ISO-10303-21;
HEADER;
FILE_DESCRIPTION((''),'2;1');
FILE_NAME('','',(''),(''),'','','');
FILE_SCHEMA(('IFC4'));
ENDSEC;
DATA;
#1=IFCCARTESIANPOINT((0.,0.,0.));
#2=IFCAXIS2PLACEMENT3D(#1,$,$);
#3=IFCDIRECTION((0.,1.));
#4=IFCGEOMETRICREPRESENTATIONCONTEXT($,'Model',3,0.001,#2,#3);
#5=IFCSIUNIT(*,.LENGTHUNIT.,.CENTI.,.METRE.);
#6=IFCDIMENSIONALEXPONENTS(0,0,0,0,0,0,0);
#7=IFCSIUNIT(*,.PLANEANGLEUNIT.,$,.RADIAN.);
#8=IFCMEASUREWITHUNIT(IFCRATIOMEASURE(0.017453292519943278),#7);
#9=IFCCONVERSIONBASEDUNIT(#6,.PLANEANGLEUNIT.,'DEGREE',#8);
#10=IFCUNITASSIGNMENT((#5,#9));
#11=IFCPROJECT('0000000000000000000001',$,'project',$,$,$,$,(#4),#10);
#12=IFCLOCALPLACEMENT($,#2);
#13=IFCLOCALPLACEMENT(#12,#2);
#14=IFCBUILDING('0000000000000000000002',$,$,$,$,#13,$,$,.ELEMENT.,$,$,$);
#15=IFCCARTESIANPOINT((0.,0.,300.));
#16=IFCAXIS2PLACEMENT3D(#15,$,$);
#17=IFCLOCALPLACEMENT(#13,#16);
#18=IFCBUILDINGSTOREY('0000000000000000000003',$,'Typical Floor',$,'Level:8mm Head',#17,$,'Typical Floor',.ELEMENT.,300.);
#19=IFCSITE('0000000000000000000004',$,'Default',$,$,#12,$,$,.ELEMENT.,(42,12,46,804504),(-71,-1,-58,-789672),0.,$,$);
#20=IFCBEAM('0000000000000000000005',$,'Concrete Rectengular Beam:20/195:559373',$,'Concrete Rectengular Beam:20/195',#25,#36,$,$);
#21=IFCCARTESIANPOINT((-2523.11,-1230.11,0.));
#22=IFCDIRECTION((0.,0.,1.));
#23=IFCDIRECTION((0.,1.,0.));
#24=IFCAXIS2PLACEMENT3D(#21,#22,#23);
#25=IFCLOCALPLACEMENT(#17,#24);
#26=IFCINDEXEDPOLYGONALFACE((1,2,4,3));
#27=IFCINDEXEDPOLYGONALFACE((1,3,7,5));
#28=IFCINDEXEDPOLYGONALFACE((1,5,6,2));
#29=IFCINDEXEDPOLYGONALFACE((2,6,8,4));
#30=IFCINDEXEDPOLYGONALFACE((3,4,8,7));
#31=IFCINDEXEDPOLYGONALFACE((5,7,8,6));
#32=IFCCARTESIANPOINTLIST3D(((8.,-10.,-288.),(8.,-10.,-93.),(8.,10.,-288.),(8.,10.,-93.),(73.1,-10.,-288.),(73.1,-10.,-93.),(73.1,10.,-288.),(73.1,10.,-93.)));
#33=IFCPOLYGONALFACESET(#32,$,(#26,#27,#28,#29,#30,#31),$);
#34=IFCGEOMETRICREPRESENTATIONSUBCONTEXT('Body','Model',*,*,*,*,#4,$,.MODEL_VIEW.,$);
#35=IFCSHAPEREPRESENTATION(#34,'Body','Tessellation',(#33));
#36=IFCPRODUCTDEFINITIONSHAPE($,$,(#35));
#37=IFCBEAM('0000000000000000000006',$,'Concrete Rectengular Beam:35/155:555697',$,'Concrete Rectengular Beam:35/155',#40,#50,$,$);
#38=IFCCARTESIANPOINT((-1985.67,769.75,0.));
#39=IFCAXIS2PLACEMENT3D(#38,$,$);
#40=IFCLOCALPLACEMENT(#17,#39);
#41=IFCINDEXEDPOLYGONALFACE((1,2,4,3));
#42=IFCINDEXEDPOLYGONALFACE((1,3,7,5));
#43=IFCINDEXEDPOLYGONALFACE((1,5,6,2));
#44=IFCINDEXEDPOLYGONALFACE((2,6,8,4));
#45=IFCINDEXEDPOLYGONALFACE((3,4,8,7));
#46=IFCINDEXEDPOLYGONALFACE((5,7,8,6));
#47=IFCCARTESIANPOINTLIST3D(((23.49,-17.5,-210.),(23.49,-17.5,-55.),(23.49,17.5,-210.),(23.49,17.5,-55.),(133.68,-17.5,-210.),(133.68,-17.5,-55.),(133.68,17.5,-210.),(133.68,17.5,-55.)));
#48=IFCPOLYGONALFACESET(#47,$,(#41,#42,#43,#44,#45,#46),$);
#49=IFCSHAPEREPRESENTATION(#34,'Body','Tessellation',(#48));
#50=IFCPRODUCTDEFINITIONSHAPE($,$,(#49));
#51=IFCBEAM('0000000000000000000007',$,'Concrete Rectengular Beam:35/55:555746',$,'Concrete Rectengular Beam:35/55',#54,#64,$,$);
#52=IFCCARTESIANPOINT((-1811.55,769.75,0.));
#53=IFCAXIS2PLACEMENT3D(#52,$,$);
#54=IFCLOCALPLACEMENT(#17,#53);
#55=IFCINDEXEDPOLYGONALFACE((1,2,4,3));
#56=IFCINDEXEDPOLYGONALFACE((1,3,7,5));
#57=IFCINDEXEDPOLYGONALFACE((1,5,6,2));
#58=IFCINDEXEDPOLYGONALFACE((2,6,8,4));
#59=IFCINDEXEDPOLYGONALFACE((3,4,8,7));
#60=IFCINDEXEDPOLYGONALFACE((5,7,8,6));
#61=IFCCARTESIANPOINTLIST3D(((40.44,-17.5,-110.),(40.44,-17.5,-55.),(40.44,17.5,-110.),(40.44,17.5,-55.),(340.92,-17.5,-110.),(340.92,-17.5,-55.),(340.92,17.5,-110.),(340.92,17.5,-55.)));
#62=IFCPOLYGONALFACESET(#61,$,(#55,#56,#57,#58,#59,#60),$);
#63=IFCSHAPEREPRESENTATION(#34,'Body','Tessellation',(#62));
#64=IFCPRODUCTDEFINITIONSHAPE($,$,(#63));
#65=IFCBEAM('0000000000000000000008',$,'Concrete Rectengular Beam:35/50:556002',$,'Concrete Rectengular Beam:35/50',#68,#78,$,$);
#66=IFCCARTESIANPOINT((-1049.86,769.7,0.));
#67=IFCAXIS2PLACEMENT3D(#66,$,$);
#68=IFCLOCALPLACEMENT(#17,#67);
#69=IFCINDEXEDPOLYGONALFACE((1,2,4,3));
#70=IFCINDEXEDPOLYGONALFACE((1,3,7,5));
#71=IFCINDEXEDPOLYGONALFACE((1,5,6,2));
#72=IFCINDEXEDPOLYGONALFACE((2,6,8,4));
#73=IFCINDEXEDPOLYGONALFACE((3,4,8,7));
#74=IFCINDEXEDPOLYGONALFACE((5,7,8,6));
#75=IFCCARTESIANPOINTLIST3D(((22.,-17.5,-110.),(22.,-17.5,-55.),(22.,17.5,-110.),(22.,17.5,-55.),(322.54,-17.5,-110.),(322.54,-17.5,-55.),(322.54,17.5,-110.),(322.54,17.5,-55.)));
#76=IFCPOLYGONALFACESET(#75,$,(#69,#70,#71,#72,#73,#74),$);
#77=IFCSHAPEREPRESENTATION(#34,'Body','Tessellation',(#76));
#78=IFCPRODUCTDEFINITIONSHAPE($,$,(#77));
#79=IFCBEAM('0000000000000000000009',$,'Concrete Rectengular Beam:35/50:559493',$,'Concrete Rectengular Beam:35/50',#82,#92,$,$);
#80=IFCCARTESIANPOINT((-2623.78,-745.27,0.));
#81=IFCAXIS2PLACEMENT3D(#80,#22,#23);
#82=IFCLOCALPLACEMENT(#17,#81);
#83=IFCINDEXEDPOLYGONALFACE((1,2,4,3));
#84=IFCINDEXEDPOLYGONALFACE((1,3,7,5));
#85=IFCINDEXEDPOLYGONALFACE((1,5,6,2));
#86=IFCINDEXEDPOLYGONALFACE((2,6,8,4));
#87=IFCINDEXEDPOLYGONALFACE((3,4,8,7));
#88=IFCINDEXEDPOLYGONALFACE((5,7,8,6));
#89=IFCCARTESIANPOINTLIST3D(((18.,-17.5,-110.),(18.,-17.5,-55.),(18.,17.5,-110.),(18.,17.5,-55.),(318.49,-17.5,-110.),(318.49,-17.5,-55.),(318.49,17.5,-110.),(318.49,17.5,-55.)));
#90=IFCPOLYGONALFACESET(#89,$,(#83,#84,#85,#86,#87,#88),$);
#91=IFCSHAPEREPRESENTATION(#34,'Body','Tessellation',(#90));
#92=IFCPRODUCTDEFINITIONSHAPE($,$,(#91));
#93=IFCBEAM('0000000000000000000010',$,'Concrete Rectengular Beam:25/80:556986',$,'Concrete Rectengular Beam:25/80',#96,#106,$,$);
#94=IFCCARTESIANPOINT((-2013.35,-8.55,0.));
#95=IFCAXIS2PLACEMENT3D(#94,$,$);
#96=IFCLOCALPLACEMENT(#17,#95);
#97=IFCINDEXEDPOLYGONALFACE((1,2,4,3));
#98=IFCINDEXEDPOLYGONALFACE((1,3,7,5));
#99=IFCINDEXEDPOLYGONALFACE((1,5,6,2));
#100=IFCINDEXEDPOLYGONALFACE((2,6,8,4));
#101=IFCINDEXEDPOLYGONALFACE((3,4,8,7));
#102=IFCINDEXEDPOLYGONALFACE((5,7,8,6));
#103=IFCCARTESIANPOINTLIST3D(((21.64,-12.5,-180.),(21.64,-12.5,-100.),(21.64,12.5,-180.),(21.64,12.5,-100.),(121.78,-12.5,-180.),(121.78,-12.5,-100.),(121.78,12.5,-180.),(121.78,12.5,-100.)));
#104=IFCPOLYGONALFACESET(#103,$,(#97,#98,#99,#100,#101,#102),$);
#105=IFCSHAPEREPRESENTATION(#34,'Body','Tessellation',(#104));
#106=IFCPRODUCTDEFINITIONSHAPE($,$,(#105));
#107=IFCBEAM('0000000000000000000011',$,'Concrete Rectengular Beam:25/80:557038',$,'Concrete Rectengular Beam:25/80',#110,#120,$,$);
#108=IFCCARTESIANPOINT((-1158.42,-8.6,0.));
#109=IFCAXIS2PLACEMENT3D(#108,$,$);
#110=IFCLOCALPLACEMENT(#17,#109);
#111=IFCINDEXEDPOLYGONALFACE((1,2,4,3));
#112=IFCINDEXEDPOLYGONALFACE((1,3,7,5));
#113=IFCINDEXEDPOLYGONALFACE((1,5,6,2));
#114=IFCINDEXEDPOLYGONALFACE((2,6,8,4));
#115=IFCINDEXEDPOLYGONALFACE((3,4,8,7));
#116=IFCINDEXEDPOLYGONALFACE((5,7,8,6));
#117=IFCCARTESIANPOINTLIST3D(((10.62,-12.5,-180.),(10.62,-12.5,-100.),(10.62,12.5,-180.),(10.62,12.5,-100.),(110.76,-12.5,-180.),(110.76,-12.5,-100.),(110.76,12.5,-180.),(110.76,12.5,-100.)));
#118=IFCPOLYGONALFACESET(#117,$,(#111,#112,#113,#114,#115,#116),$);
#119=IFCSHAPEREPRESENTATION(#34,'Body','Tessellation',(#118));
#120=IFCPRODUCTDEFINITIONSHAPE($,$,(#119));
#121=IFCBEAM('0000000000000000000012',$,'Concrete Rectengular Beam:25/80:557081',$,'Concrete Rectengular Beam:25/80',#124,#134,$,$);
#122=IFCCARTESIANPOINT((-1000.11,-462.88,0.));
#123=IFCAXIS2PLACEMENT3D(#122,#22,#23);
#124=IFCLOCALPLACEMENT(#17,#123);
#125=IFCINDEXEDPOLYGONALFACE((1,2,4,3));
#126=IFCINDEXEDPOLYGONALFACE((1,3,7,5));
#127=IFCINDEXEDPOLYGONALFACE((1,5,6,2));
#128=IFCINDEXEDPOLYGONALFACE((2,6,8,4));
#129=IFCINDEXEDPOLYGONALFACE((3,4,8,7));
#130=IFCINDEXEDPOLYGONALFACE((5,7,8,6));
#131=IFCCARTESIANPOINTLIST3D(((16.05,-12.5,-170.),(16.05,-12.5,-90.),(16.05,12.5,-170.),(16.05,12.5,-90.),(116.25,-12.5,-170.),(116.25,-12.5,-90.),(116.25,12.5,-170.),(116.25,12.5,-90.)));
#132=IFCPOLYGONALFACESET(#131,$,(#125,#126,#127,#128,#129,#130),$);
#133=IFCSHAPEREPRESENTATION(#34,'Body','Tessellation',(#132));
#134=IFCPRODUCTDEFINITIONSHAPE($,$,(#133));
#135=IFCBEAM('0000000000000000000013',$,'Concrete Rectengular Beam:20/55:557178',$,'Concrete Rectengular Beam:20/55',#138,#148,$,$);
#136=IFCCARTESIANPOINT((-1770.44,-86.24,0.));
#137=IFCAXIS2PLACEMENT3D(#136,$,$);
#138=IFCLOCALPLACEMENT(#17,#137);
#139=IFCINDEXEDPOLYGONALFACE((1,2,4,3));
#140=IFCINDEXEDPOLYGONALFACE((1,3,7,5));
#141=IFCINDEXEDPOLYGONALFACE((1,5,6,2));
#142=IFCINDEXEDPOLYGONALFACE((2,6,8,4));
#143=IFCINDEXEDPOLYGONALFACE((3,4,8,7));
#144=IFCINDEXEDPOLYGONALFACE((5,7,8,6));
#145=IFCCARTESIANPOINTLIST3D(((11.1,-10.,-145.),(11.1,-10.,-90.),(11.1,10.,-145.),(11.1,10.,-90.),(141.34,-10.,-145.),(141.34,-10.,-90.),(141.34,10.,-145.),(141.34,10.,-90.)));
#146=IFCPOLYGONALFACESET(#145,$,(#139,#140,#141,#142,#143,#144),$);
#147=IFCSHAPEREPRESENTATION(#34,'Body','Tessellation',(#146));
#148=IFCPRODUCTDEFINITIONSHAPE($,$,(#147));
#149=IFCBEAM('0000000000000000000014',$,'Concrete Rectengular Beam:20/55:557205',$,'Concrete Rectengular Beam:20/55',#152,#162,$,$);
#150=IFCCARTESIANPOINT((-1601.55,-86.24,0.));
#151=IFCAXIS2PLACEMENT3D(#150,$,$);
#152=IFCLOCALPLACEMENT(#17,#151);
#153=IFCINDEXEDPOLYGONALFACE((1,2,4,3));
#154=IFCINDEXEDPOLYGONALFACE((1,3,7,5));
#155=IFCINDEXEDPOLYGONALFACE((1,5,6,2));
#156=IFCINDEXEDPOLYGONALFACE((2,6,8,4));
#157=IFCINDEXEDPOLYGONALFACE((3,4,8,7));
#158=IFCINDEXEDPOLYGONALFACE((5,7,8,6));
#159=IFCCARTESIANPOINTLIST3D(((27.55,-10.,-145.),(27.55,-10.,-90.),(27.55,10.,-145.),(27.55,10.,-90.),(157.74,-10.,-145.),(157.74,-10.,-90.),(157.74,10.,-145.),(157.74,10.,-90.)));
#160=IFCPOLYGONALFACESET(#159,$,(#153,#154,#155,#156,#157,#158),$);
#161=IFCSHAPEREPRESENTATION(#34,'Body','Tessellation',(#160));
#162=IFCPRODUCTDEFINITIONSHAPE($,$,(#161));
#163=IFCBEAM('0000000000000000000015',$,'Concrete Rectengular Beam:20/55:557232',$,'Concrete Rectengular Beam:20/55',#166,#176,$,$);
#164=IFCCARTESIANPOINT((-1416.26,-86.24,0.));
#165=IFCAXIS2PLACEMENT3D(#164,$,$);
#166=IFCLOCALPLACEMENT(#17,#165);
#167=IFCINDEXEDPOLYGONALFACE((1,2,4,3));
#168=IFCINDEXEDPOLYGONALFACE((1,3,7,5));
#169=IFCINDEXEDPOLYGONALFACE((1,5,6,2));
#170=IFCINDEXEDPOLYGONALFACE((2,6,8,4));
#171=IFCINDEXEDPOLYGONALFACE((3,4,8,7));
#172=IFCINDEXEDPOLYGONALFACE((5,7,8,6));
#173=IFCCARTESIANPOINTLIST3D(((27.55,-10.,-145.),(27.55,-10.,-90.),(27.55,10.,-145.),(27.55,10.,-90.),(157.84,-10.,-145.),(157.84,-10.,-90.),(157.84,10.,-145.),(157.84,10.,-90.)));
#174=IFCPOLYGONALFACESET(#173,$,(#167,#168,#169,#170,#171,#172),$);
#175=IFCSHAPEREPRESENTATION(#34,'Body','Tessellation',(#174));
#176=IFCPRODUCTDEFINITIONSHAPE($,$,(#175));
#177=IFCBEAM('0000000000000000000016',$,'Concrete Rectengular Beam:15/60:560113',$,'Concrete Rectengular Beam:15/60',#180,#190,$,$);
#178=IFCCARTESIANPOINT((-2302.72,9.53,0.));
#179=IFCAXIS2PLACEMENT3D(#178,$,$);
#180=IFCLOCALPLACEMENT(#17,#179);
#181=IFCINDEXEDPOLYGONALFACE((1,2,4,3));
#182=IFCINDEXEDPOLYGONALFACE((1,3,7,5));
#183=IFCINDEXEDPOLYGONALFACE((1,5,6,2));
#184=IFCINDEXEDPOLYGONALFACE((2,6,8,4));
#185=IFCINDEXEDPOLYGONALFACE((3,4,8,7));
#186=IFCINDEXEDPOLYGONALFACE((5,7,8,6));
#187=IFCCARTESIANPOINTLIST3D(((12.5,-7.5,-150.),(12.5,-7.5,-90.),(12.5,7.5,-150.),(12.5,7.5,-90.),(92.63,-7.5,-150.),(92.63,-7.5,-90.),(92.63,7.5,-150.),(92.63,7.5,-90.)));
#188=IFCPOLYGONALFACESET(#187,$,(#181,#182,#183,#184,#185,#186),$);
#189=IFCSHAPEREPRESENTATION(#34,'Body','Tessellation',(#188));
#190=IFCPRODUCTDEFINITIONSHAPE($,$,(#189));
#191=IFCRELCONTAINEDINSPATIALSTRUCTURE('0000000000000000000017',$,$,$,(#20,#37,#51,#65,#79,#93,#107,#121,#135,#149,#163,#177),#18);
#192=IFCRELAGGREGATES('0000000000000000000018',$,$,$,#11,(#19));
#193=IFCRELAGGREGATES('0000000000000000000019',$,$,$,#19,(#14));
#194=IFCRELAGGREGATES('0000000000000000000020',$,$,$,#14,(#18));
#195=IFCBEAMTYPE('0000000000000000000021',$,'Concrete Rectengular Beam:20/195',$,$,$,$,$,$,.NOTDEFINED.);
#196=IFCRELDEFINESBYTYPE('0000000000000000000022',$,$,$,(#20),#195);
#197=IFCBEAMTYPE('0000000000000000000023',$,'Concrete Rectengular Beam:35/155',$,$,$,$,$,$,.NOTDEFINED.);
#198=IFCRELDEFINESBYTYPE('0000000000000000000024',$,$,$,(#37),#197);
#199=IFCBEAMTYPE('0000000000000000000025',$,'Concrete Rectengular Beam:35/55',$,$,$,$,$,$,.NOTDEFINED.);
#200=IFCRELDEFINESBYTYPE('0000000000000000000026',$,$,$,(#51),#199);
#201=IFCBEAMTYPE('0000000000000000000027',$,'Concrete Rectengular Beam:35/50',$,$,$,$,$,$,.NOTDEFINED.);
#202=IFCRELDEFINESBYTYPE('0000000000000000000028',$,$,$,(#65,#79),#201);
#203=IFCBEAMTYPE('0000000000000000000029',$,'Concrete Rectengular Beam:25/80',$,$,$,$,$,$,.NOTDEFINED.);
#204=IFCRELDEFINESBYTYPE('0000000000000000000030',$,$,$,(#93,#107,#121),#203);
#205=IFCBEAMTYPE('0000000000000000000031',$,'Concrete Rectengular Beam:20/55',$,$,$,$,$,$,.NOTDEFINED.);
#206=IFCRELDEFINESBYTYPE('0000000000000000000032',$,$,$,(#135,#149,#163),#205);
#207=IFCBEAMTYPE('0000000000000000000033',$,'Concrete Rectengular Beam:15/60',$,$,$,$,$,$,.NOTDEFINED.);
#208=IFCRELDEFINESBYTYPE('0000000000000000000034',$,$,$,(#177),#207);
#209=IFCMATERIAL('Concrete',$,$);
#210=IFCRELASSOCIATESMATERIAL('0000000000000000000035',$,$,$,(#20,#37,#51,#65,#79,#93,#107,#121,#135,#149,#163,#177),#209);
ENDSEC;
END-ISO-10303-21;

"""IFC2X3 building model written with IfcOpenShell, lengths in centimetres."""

from ifc_helpers import new_model, entity, si_unit, converted_unit, direction, frame, frame_2d, origin, origin_2d_with_axis, place, context, subcontext, project, spatial, rectangle, extrude, material, type_object, element, save


model = new_model("IFC2X3")

# Units and contexts
model_context = context("Model", 3, precision=0.001, world=origin(), true_north=direction((0.0, 1.0)))
body_context = subcontext(model_context, "Body", "Model", "MODEL_VIEW")
ifc_project = project(units=[si_unit("LENGTHUNIT", "METRE", prefix="CENTI"), converted_unit("PLANEANGLEUNIT", "DEGREE", entity("IfcRatioMeasure", 0.017453292519943278), si_unit("PLANEANGLEUNIT", "RADIAN"), dimensions=[0, 0, 0, 0, 0, 0, 0])], contexts=[model_context])

# Site, building, storey
site_placement = place(None, origin())
site = spatial("IfcSite", under=ifc_project, at=site_placement, Name="Default", CompositionType="ELEMENT", RefLatitude=(42, 12, 46, 804504), RefLongitude=(-71, -1, -58, -789672), RefElevation=0.0)
building_placement = place(site_placement, origin())
building = spatial("IfcBuilding", under=site, at=building_placement, CompositionType="ELEMENT")
storey_placement = place(building_placement, frame((0.0, 0.0, 300.0)))
storey = spatial("IfcBuildingStorey", under=building, at=storey_placement, Name="Typical Floor", ObjectType="Level:8mm Head", LongName="Typical Floor", CompositionType="ELEMENT", Elevation=300.0)

# Beams
ifc_material = material(Name="Concrete")
beam_type_1 = type_object("IfcBeamType", Name="Concrete Rectengular Beam:20/195", PredefinedType="NOTDEFINED")
beam_1_placement = place(storey_placement, frame((-2523.11, -1230.11, 0.0), z_axis=(0.0, 0.0, 1.0), x_axis=(0.0, 1.0, 0.0)))
element("IfcBeam", 1, at=beam_1_placement, inside=storey, type_object=beam_type_1, material=ifc_material, Name="Concrete Rectengular Beam:20/195:559373", ObjectType="Concrete Rectengular Beam:20/195", context=body_context, shape_type="SweptSolid", body=[
    extrude(rectangle(XDim=195.0, YDim=20.0, at=frame_2d((0.0, 0.0), x_axis=(1.0, 0.0))), frame((8.0, 0.0, -190.5), z_axis=(1.0, 0.0, 0.0), x_axis=(0.0, 0.0, -1.0)), (0.0, 0.0, 1.0), 65.1),
])
beam_type_2 = type_object("IfcBeamType", Name="Concrete Rectengular Beam:35/155", PredefinedType="NOTDEFINED")
beam_2_placement = place(storey_placement, frame((-1985.67, 769.75, 0.0)))
element("IfcBeam", 2, at=beam_2_placement, inside=storey, type_object=beam_type_2, material=ifc_material, Name="Concrete Rectengular Beam:35/155:555697", ObjectType="Concrete Rectengular Beam:35/155", context=body_context, shape_type="SweptSolid", body=[
    extrude(rectangle(XDim=155.0, YDim=35.0, at=frame_2d((0.0, 0.0), x_axis=(1.0, 0.0))), frame((23.49, 0.0, -132.5), z_axis=(1.0, 0.0, 0.0), x_axis=(0.0, 0.0, -1.0)), (0.0, 0.0, 1.0), 110.2),
])
beam_type_3 = type_object("IfcBeamType", Name="Concrete Rectengular Beam:35/55", PredefinedType="NOTDEFINED")
beam_3_placement = place(storey_placement, frame((-1811.55, 769.75, 0.0)))
element("IfcBeam", 3, at=beam_3_placement, inside=storey, type_object=beam_type_3, material=ifc_material, Name="Concrete Rectengular Beam:35/55:555746", ObjectType="Concrete Rectengular Beam:35/55", context=body_context, shape_type="SweptSolid", body=[
    extrude(rectangle(XDim=55.0, YDim=35.0, at=frame_2d((0.0, 0.0), x_axis=(1.0, 0.0))), frame((40.44, 0.0, -82.5), z_axis=(1.0, 0.0, 0.0), x_axis=(0.0, 0.0, -1.0)), (0.0, 0.0, 1.0), 300.49),
])
beam_type_4 = type_object("IfcBeamType", Name="Concrete Rectengular Beam:35/50", PredefinedType="NOTDEFINED")
beam_4_placement = place(storey_placement, frame((-1049.86, 769.7, 0.0)))
element("IfcBeam", 4, at=beam_4_placement, inside=storey, type_object=beam_type_4, material=ifc_material, Name="Concrete Rectengular Beam:35/50:556002", ObjectType="Concrete Rectengular Beam:35/50", context=body_context, shape_type="SweptSolid", body=[
    extrude(rectangle(XDim=55.0, YDim=35.0, at=frame_2d((0.0, 0.0), x_axis=(1.0, 0.0))), frame((22.0, 0.0, -82.5), z_axis=(1.0, 0.0, 0.0), x_axis=(0.0, 0.0, -1.0)), (0.0, 0.0, 1.0), 300.54),
])
beam_5_placement = place(storey_placement, frame((-2623.78, -745.27, 0.0), z_axis=(0.0, 0.0, 1.0), x_axis=(0.0, 1.0, 0.0)))
element("IfcBeam", 5, at=beam_5_placement, inside=storey, type_object=beam_type_4, material=ifc_material, Name="Concrete Rectengular Beam:35/50:559493", ObjectType="Concrete Rectengular Beam:35/50", context=body_context, shape_type="SweptSolid", body=[
    extrude(rectangle(XDim=55.0, YDim=35.0, at=origin_2d_with_axis()), frame((18.0, 0.0, -82.5), z_axis=(1.0, 0.0, 0.0), x_axis=(0.0, 0.0, -1.0)), (0.0, 0.0, 1.0), 300.49),
])
beam_type_5 = type_object("IfcBeamType", Name="Concrete Rectengular Beam:25/80", PredefinedType="NOTDEFINED")
beam_6_placement = place(storey_placement, frame((-2013.35, -8.55, 0.0)))
element("IfcBeam", 6, at=beam_6_placement, inside=storey, type_object=beam_type_5, material=ifc_material, Name="Concrete Rectengular Beam:25/80:556986", ObjectType="Concrete Rectengular Beam:25/80", context=body_context, shape_type="SweptSolid", body=[
    extrude(rectangle(XDim=80.0, YDim=25.0, at=frame_2d((0.0, 0.0), x_axis=(1.0, 0.0))), frame((21.64, 0.0, -140.0), z_axis=(1.0, 0.0, 0.0), x_axis=(0.0, 0.0, -1.0)), (0.0, 0.0, 1.0), 100.14),
])
beam_7_placement = place(storey_placement, frame((-1158.42, -8.6, 0.0)))
element("IfcBeam", 7, at=beam_7_placement, inside=storey, type_object=beam_type_5, material=ifc_material, Name="Concrete Rectengular Beam:25/80:557038", ObjectType="Concrete Rectengular Beam:25/80", context=body_context, shape_type="SweptSolid", body=[
    extrude(rectangle(XDim=80.0, YDim=25.0, at=frame_2d((0.0, 0.0), x_axis=(1.0, 0.0))), frame((10.62, 0.0, -140.0), z_axis=(1.0, 0.0, 0.0), x_axis=(0.0, 0.0, -1.0)), (0.0, 0.0, 1.0), 100.14),
])
beam_8_placement = place(storey_placement, frame((-1000.11, -462.88, 0.0), z_axis=(0.0, 0.0, 1.0), x_axis=(0.0, 1.0, 0.0)))
element("IfcBeam", 8, at=beam_8_placement, inside=storey, type_object=beam_type_5, material=ifc_material, Name="Concrete Rectengular Beam:25/80:557081", ObjectType="Concrete Rectengular Beam:25/80", context=body_context, shape_type="SweptSolid", body=[
    extrude(rectangle(XDim=80.0, YDim=25.0, at=origin_2d_with_axis()), frame((16.05, 0.0, -130.0), z_axis=(1.0, 0.0, 0.0), x_axis=(0.0, 0.0, -1.0)), (0.0, 0.0, 1.0), 100.2),
])
beam_type_6 = type_object("IfcBeamType", Name="Concrete Rectengular Beam:20/55", PredefinedType="NOTDEFINED")
beam_9_placement = place(storey_placement, frame((-1770.44, -86.24, 0.0)))
element("IfcBeam", 9, at=beam_9_placement, inside=storey, type_object=beam_type_6, material=ifc_material, Name="Concrete Rectengular Beam:20/55:557178", ObjectType="Concrete Rectengular Beam:20/55", context=body_context, shape_type="SweptSolid", body=[
    extrude(rectangle(XDim=55.0, YDim=20.0, at=frame_2d((0.0, 0.0), x_axis=(1.0, 0.0))), frame((11.1, 0.0, -117.5), z_axis=(1.0, 0.0, 0.0), x_axis=(0.0, 0.0, -1.0)), (0.0, 0.0, 1.0), 130.25),
])
beam_10_placement = place(storey_placement, frame((-1601.55, -86.24, 0.0)))
element("IfcBeam", 10, at=beam_10_placement, inside=storey, type_object=beam_type_6, material=ifc_material, Name="Concrete Rectengular Beam:20/55:557205", ObjectType="Concrete Rectengular Beam:20/55", context=body_context, shape_type="SweptSolid", body=[
    extrude(rectangle(XDim=55.0, YDim=20.0, at=frame_2d((0.0, 0.0), x_axis=(1.0, 0.0))), frame((27.55, 0.0, -117.5), z_axis=(1.0, 0.0, 0.0), x_axis=(0.0, 0.0, -1.0)), (0.0, 0.0, 1.0), 130.19),
])
beam_11_placement = place(storey_placement, frame((-1416.26, -86.24, 0.0)))
element("IfcBeam", 11, at=beam_11_placement, inside=storey, type_object=beam_type_6, material=ifc_material, Name="Concrete Rectengular Beam:20/55:557232", ObjectType="Concrete Rectengular Beam:20/55", context=body_context, shape_type="SweptSolid", body=[
    extrude(rectangle(XDim=55.0, YDim=20.0, at=frame_2d((0.0, 0.0), x_axis=(1.0, 0.0))), frame((27.55, 0.0, -117.5), z_axis=(1.0, 0.0, 0.0), x_axis=(0.0, 0.0, -1.0)), (0.0, 0.0, 1.0), 130.29),
])
beam_type_7 = type_object("IfcBeamType", Name="Concrete Rectengular Beam:15/60", PredefinedType="NOTDEFINED")
beam_12_placement = place(storey_placement, frame((-2302.72, 9.53, 0.0)))
element("IfcBeam", 12, at=beam_12_placement, inside=storey, type_object=beam_type_7, material=ifc_material, Name="Concrete Rectengular Beam:15/60:560113", ObjectType="Concrete Rectengular Beam:15/60", context=body_context, shape_type="SweptSolid", body=[
    extrude(rectangle(XDim=60.0, YDim=15.0, at=frame_2d((0.0, 0.0), x_axis=(1.0, 0.0))), frame((12.5, 0.0, -120.0), z_axis=(1.0, 0.0, 0.0), x_axis=(0.0, 0.0, -1.0)), (0.0, 0.0, 1.0), 80.13),
])

save(model, "model.ifc")
